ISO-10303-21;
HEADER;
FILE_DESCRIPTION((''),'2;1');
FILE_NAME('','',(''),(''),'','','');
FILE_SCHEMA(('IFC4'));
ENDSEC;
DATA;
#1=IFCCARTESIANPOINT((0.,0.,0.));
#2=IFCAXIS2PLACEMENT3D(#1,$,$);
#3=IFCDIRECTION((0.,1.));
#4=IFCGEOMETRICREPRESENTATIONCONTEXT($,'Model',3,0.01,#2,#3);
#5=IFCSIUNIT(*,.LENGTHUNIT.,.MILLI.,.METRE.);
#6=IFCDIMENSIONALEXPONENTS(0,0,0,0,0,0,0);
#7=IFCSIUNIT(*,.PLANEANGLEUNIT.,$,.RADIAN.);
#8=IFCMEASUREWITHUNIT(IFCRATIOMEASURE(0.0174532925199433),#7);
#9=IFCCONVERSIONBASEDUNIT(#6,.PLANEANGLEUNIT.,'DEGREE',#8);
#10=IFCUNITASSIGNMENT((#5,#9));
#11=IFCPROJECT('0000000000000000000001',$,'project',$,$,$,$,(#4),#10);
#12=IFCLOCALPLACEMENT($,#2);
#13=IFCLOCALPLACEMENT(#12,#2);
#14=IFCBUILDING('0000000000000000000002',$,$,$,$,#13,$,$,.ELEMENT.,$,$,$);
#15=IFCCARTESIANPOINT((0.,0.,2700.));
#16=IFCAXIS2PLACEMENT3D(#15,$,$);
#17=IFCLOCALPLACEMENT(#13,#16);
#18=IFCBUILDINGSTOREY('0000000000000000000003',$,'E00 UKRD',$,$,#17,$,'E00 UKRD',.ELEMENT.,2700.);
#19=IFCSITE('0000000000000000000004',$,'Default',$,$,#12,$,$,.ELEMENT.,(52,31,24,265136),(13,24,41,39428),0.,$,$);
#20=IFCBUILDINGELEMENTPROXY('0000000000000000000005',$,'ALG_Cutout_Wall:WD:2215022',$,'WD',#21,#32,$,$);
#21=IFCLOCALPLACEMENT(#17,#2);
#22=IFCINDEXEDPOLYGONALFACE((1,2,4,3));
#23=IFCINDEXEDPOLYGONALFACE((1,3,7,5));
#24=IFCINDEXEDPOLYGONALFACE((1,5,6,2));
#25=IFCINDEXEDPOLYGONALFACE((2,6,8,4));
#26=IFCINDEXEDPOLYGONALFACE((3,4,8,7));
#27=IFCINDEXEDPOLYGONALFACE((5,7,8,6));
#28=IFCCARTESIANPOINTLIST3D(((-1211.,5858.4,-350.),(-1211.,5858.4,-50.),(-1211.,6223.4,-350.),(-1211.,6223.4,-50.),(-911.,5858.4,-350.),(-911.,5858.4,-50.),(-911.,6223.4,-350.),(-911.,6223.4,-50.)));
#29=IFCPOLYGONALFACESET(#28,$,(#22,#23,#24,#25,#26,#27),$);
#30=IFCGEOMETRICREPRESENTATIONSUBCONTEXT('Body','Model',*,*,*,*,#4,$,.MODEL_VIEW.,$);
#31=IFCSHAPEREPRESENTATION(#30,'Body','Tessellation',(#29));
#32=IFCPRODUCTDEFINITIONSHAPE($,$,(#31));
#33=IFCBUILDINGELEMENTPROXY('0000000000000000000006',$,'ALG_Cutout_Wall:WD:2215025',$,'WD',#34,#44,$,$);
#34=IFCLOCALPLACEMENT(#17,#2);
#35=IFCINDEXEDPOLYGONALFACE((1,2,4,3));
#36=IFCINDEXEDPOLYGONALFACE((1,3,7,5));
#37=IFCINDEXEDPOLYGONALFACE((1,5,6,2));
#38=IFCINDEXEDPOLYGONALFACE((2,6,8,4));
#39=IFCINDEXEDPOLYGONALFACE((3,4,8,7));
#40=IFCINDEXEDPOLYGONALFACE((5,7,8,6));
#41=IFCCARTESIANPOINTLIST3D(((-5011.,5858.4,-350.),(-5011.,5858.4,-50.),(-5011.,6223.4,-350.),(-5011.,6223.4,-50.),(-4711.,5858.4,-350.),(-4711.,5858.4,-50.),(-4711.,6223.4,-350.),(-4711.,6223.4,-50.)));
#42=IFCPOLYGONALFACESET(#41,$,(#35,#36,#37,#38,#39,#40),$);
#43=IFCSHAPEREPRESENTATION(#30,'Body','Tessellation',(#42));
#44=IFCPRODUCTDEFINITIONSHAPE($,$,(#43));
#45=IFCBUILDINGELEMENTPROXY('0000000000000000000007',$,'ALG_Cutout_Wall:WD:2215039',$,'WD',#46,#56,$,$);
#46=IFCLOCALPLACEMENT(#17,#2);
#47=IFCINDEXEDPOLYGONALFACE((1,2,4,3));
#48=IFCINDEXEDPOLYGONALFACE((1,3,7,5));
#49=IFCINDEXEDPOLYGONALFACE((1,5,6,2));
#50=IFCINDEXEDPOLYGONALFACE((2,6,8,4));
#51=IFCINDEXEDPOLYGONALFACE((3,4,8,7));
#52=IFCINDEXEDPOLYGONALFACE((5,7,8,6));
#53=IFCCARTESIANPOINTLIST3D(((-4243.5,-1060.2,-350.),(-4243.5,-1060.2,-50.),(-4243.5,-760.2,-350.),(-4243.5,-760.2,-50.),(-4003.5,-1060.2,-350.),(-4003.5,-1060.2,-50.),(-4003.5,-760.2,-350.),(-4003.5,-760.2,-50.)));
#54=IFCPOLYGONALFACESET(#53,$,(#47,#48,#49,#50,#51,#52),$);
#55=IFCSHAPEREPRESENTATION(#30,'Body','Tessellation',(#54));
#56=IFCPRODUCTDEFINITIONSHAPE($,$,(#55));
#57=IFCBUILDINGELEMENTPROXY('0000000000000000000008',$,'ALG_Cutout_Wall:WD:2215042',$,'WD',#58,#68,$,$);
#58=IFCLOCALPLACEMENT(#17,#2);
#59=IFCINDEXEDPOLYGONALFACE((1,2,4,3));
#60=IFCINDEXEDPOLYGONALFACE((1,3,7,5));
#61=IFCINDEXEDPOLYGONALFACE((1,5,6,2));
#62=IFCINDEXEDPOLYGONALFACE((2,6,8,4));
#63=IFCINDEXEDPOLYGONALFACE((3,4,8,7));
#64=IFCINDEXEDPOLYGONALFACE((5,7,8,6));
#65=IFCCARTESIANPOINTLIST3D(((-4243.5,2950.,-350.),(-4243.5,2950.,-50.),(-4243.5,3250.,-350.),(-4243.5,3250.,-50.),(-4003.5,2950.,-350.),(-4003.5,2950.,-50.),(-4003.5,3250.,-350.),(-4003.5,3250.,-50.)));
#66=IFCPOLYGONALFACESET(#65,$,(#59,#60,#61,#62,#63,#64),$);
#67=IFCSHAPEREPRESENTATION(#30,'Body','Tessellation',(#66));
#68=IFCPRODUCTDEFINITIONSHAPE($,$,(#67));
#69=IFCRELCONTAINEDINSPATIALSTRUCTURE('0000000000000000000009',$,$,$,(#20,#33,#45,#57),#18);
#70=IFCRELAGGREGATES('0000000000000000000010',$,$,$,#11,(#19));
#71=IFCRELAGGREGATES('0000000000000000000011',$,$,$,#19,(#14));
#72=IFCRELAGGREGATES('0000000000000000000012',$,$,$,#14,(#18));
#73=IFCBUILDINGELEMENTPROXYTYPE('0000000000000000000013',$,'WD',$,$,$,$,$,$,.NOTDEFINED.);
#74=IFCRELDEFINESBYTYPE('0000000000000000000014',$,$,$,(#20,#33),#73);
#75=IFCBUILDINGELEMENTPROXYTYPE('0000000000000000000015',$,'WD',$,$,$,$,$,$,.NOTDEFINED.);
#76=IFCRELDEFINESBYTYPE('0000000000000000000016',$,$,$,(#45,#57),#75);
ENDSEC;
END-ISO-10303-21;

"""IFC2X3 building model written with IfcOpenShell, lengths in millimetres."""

from ifc_helpers import new_model, entity, si_unit, converted_unit, direction, frame, origin, origin_2d_with_axis, place, context, subcontext, project, spatial, rectangle, extrude, source, transform, mapped, type_object, type_shapes, element, save


model = new_model("IFC2X3")

# Units and contexts
model_context = context("Model", 3, precision=0.01, world=origin(), true_north=direction((0.0, 1.0)))
body_context = subcontext(model_context, "Body", "Model", "MODEL_VIEW")
ifc_project = project(units=[si_unit("LENGTHUNIT", "METRE", prefix="MILLI"), converted_unit("PLANEANGLEUNIT", "DEGREE", entity("IfcRatioMeasure", 0.0174532925199433), si_unit("PLANEANGLEUNIT", "RADIAN"), dimensions=[0, 0, 0, 0, 0, 0, 0])], contexts=[model_context])

# Site, building, storey
site_placement = place(None, origin())
site = spatial("IfcSite", under=ifc_project, at=site_placement, Name="Default", CompositionType="ELEMENT", RefLatitude=(52, 31, 24, 265136), RefLongitude=(13, 24, 41, 39428), RefElevation=0.0)
building_placement = place(site_placement, origin())
building = spatial("IfcBuilding", under=site, at=building_placement, CompositionType="ELEMENT")
storey_placement = place(building_placement, frame((0.0, 0.0, 2700.0)))
storey = spatial("IfcBuildingStorey", under=building, at=storey_placement, Name="E00 UKRD", LongName="E00 UKRD", CompositionType="ELEMENT", Elevation=2700.0)

# Building element proxies
building_element_proxy_type_1 = type_object("IfcBuildingElementProxyType", Name="WD", PredefinedType="NOTDEFINED")
shared_shape_1 = source(origin(), body_context, "Body", "SweptSolid", [
    extrude(rectangle(XDim=365.0, YDim=300.0, at=origin_2d_with_axis()), frame((0.0, 0.0, -350.0), z_axis=(0.0, 0.0, 1.0), x_axis=(0.0, 1.0, 0.0)), (0.0, 0.0, 1.0), 300.0),
])
type_shapes(building_element_proxy_type_1, [shared_shape_1])
for number, where, name in (
    (1, (-1061.0, 6040.9, 0.0), "ALG_Cutout_Wall:WD:2215022"),
    (2, (-4861.0, 6040.9, 0.0), "ALG_Cutout_Wall:WD:2215025"),
):
    element("IfcBuildingElementProxy", number, at=place(storey_placement, frame(where)), inside=storey, type_object=building_element_proxy_type_1, Name=name, ObjectType="WD", context=body_context, shape_type="MappedRepresentation", body=[
        mapped(shared_shape_1, transform((0.0, 0.0, 0.0), scale=1.0)),
    ])
building_element_proxy_type_2 = type_object("IfcBuildingElementProxyType", Name="WD", PredefinedType="NOTDEFINED")
shared_shape_2 = source(origin(), body_context, "Body", "SweptSolid", [
    extrude(rectangle(XDim=240.0, YDim=300.0, at=origin_2d_with_axis()), frame((0.0, 0.0, -350.0), z_axis=(0.0, 0.0, 1.0), x_axis=(0.0, 1.0, 0.0)), (0.0, 0.0, 1.0), 300.0),
])
type_shapes(building_element_proxy_type_2, [shared_shape_2])
for number, where, z_axis, x_axis, name in (
    (3, (-4123.5, -910.2, 0.0), (0.0, 0.0, 1.0), (0.0, 1.0, 0.0), "ALG_Cutout_Wall:WD:2215039"),
    (4, (-4123.5, 3100.0, 0.0), (0.0, 0.0, 1.0), (0.0, 1.0, 0.0), "ALG_Cutout_Wall:WD:2215042"),
):
    element("IfcBuildingElementProxy", number, at=place(storey_placement, frame(where, z_axis=z_axis, x_axis=x_axis)), inside=storey, type_object=building_element_proxy_type_2, Name=name, ObjectType="WD", context=body_context, shape_type="MappedRepresentation", body=[
        mapped(shared_shape_2, transform((0.0, 0.0, 0.0), scale=1.0)),
    ])

save(model, "model.ifc")
